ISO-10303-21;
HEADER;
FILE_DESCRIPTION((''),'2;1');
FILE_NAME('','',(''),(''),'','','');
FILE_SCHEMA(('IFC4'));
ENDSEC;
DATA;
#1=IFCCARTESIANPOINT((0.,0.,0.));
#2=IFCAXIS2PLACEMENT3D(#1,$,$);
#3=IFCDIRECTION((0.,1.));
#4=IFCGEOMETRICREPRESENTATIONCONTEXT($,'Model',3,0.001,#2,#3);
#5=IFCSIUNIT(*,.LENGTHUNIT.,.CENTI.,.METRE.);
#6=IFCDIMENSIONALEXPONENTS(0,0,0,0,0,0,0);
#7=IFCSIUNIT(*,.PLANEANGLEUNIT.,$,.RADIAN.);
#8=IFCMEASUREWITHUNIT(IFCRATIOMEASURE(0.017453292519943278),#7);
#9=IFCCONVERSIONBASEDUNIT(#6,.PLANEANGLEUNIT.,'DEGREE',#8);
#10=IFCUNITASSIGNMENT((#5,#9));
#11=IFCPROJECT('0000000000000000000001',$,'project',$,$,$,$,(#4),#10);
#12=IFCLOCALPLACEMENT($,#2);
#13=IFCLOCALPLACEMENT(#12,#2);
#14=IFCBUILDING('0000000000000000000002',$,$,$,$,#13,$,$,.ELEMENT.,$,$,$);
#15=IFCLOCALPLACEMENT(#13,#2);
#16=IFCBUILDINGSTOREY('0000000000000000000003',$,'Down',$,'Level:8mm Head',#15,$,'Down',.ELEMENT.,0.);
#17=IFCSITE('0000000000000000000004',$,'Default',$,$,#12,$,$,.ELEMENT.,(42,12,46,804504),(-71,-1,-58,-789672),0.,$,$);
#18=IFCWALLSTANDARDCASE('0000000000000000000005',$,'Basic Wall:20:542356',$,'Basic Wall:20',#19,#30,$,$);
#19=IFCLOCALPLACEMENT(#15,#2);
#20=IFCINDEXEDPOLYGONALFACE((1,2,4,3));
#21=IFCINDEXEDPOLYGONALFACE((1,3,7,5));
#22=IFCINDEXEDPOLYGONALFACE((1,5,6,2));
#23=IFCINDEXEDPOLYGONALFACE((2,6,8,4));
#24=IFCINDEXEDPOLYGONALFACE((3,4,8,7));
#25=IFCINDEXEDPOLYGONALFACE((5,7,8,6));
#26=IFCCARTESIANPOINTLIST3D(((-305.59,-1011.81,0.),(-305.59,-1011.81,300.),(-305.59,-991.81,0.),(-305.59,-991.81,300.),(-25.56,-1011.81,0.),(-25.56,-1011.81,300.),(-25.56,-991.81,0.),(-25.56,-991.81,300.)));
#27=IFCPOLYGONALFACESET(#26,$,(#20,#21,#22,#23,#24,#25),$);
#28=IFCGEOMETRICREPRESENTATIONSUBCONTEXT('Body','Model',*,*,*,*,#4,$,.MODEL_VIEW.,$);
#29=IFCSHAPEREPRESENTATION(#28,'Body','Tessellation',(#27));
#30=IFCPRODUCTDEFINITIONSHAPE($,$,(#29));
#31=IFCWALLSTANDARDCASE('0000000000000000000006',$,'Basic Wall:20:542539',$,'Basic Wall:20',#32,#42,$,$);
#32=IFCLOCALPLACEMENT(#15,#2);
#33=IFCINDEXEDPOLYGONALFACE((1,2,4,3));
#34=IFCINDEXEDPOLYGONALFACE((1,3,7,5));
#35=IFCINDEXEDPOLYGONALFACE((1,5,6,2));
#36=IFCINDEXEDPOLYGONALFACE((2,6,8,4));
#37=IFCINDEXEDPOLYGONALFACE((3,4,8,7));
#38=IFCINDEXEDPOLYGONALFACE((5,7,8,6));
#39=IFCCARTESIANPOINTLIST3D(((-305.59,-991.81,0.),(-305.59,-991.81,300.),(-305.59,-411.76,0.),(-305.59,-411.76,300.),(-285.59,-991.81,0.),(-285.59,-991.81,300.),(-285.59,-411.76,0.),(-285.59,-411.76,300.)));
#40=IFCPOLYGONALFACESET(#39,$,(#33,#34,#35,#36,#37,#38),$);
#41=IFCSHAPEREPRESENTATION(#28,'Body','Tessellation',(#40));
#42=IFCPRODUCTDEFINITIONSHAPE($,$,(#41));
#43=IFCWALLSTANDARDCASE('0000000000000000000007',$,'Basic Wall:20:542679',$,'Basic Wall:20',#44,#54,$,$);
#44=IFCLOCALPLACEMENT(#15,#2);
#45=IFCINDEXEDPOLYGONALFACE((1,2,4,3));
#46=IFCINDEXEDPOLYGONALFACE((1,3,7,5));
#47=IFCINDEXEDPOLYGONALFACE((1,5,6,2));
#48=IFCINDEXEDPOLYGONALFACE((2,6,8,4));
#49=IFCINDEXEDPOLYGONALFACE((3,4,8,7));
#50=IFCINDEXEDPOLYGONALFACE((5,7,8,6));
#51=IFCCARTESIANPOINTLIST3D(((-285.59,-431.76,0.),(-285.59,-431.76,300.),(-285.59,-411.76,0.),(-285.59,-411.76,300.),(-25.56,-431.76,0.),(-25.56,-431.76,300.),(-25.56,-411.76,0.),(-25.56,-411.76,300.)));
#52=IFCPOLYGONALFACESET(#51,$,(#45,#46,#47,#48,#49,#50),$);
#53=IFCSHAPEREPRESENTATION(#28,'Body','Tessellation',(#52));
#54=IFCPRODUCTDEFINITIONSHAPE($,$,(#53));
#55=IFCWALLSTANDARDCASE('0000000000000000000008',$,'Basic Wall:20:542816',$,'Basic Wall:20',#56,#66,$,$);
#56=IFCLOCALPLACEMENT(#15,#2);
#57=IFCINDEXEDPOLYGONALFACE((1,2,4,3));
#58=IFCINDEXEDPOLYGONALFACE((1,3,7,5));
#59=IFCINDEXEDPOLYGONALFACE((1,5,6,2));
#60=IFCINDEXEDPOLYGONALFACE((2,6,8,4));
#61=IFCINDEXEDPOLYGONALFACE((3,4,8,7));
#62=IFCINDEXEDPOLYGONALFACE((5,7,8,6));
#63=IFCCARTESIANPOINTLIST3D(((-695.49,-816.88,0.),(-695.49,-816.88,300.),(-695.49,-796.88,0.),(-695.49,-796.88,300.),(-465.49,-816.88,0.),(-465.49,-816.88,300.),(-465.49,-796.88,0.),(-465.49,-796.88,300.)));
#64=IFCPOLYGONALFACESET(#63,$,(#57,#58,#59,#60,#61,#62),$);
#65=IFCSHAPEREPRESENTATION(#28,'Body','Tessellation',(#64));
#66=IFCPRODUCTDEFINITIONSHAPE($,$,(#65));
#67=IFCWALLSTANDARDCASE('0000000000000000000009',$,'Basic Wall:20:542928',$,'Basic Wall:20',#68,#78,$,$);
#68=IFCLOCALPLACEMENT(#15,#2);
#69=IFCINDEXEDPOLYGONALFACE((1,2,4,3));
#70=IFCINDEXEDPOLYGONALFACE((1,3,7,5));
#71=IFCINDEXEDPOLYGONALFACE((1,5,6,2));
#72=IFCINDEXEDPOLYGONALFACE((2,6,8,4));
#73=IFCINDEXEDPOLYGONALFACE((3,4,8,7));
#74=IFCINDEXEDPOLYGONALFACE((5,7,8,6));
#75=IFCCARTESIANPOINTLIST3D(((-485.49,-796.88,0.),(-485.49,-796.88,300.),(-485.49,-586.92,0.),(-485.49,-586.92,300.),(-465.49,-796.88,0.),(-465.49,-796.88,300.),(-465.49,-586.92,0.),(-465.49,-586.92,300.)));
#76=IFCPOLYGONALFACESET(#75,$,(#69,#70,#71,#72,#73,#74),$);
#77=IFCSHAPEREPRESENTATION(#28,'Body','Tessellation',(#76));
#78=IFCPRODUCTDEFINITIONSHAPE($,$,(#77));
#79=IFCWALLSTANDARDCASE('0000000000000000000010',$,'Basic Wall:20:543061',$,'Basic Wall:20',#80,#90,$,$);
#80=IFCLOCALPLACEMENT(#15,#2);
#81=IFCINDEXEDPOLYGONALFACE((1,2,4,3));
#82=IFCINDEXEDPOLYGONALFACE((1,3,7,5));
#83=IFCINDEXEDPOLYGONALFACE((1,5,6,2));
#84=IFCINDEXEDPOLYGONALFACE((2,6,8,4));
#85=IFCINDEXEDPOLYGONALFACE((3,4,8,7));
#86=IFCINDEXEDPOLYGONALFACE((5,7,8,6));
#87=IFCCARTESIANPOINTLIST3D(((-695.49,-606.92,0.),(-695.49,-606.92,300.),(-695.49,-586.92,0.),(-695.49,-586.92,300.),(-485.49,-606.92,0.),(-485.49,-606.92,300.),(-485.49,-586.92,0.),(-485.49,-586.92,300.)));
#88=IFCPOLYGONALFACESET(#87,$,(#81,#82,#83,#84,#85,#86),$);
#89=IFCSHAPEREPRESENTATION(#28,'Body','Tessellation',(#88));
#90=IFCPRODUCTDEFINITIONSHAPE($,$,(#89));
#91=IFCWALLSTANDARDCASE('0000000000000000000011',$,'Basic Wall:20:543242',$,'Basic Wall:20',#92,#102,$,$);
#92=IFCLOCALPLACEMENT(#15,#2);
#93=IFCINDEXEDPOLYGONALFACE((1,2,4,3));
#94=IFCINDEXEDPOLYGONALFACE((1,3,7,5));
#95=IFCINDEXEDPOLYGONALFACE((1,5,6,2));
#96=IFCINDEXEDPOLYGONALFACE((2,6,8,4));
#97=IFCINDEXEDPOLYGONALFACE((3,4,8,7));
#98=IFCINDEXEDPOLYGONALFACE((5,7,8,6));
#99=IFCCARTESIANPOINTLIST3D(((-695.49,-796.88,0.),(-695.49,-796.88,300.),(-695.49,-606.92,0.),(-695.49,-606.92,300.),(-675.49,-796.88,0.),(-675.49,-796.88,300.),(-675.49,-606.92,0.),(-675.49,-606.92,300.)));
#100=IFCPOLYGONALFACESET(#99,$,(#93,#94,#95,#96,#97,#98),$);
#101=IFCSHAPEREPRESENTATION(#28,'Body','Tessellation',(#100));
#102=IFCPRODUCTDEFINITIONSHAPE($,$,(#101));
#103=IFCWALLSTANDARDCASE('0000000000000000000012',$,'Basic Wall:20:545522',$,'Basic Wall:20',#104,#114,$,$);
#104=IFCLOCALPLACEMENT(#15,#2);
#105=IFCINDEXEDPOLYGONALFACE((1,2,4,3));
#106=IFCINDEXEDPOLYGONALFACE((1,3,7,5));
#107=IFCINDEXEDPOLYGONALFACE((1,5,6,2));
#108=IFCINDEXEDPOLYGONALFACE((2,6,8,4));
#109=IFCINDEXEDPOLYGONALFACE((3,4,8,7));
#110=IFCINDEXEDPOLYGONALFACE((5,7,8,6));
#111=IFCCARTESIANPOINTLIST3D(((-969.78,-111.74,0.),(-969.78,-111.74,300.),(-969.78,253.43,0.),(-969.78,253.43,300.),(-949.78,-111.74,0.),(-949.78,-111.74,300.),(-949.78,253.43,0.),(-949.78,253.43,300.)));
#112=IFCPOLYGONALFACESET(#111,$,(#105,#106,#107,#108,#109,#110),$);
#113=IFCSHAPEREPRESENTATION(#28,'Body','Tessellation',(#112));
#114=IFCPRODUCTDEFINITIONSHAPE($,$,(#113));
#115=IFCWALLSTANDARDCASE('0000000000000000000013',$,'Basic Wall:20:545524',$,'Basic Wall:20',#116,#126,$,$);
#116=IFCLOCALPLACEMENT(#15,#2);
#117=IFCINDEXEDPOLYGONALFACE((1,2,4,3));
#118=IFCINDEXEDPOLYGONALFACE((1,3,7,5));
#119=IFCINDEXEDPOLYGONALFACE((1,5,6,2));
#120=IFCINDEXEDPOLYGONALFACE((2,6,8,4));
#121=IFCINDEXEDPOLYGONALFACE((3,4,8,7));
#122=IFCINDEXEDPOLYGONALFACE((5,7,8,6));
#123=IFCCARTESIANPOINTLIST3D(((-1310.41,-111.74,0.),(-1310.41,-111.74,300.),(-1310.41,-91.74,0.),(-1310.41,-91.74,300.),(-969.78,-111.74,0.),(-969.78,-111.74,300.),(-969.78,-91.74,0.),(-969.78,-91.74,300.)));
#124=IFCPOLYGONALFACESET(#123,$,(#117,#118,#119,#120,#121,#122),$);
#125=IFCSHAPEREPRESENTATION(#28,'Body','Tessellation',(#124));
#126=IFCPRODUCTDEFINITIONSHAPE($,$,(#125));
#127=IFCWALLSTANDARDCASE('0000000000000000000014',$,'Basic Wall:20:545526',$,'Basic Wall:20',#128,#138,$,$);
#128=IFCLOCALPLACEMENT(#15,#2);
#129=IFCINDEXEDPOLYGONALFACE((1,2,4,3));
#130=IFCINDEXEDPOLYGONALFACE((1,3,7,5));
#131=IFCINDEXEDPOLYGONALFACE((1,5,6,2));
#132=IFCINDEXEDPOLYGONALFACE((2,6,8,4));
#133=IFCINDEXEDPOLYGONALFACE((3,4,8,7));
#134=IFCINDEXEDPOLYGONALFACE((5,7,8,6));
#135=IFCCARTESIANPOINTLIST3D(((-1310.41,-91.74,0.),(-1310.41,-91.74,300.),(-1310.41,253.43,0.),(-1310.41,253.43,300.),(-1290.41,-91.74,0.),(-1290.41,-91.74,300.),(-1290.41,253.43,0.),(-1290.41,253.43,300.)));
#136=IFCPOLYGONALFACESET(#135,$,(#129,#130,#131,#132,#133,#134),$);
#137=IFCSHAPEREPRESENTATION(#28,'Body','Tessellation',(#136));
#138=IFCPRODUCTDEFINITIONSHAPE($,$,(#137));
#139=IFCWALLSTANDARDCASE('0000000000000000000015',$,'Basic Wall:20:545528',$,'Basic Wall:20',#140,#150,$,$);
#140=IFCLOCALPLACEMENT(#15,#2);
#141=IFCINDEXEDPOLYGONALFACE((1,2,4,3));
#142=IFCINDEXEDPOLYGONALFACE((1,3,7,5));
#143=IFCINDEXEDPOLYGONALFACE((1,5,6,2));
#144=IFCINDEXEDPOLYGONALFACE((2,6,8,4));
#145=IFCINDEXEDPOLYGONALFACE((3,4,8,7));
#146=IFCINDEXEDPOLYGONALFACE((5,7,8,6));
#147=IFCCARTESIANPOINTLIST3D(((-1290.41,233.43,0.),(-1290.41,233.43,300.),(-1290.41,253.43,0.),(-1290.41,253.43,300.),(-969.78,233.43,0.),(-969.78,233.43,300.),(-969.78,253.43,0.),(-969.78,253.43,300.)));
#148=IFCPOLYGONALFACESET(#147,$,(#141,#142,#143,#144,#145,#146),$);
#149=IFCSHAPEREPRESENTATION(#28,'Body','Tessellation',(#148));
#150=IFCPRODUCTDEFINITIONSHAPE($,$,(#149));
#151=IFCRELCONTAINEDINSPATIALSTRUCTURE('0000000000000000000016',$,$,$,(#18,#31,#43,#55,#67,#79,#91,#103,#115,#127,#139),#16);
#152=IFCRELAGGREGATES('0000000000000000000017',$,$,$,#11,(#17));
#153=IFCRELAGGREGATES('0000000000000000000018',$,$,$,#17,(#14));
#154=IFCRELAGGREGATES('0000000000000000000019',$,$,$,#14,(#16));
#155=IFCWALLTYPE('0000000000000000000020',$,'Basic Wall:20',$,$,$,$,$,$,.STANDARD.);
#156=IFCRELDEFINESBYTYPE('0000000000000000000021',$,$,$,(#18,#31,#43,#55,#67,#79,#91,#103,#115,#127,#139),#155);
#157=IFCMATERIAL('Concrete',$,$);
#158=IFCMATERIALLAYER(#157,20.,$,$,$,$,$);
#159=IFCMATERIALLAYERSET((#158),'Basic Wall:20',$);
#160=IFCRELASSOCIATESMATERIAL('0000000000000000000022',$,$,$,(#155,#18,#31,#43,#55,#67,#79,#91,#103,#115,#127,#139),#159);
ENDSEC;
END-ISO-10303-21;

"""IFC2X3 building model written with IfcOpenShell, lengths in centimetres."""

from ifc_helpers import new_model, entity, si_unit, converted_unit, direction, frame, frame_2d, origin, place, context, subcontext, project, spatial, rectangle, extrude, material, layer, layer_set, layer_usage, type_object, element, save


model = new_model("IFC2X3")

# Units and contexts
model_context = context("Model", 3, precision=0.001, world=origin(), true_north=direction((0.0, 1.0)))
body_context = subcontext(model_context, "Body", "Model", "MODEL_VIEW")
ifc_project = project(units=[si_unit("LENGTHUNIT", "METRE", prefix="CENTI"), converted_unit("PLANEANGLEUNIT", "DEGREE", entity("IfcRatioMeasure", 0.017453292519943278), si_unit("PLANEANGLEUNIT", "RADIAN"), dimensions=[0, 0, 0, 0, 0, 0, 0])], contexts=[model_context])

# Site, building, storey
site_placement = place(None, origin())
site = spatial("IfcSite", under=ifc_project, at=site_placement, Name="Default", CompositionType="ELEMENT", RefLatitude=(42, 12, 46, 804504), RefLongitude=(-71, -1, -58, -789672), RefElevation=0.0)
building_placement = place(site_placement, origin())
building = spatial("IfcBuilding", under=site, at=building_placement, CompositionType="ELEMENT")
storey_placement = place(building_placement, origin())
storey = spatial("IfcBuildingStorey", under=building, at=storey_placement, Name="Down", ObjectType="Level:8mm Head", LongName="Down", CompositionType="ELEMENT", Elevation=0.0)

# Shared definitions
ifc_material = material(Name="Concrete")

# Walls
ifc_layer = layer(ifc_material, 20.0)
ifc_layer_set = layer_set([ifc_layer], Name="Basic Wall:20")
wall_type = type_object("IfcWallType", Name="Basic Wall:20", PredefinedType="STANDARD", material=ifc_layer_set)
ifc_layer_usage_1 = layer_usage(ifc_layer_set, "AXIS2", "NEGATIVE", 10.0)
wall_1_placement = place(storey_placement, frame((-25.56, -1001.81, 0.0), z_axis=(0.0, 0.0, 1.0), x_axis=(-1.0, 0.0, 0.0)))
element("IfcWallStandardCase", 1, at=wall_1_placement, inside=storey, type_object=wall_type, material=ifc_layer_usage_1, Name="Basic Wall:20:542356", ObjectType="Basic Wall:20", context=body_context, shape_type="SweptSolid", body=[
    extrude(rectangle(XDim=280.02, YDim=20.0, at=frame_2d((140.01, 0.0), x_axis=(-1.0, 0.0))), origin(), (0.0, 0.0, 1.0), 300.0),
])
ifc_layer_usage_2 = layer_usage(ifc_layer_set, "AXIS2", "NEGATIVE", 10.0)
wall_2_placement = place(storey_placement, frame((-295.59, -991.81, 0.0), z_axis=(0.0, 0.0, 1.0), x_axis=(0.0, 1.0, 0.0)))
element("IfcWallStandardCase", 2, at=wall_2_placement, inside=storey, type_object=wall_type, material=ifc_layer_usage_2, Name="Basic Wall:20:542539", ObjectType="Basic Wall:20", context=body_context, shape_type="SweptSolid", body=[
    extrude(rectangle(XDim=580.05, YDim=20.0, at=frame_2d((290.02, 0.0), x_axis=(-1.0, 0.0))), origin(), (0.0, 0.0, 1.0), 300.0),
])
ifc_layer_usage_3 = layer_usage(ifc_layer_set, "AXIS2", "NEGATIVE", 10.0)
wall_3_placement = place(storey_placement, frame((-285.59, -421.76, 0.0)))
element("IfcWallStandardCase", 3, at=wall_3_placement, inside=storey, type_object=wall_type, material=ifc_layer_usage_3, Name="Basic Wall:20:542679", ObjectType="Basic Wall:20", context=body_context, shape_type="SweptSolid", body=[
    extrude(rectangle(XDim=260.02, YDim=20.0, at=frame_2d((130.01, 0.0), x_axis=(-1.0, 0.0))), origin(), (0.0, 0.0, 1.0), 300.0),
])
ifc_layer_usage_4 = layer_usage(ifc_layer_set, "AXIS2", "POSITIVE", -10.0)
wall_4_placement = place(storey_placement, frame((-695.49, -806.88, 0.0)))
element("IfcWallStandardCase", 4, at=wall_4_placement, inside=storey, type_object=wall_type, material=ifc_layer_usage_4, Name="Basic Wall:20:542816", ObjectType="Basic Wall:20", context=body_context, shape_type="SweptSolid", body=[
    extrude(rectangle(XDim=230.0, YDim=20.0, at=frame_2d((115.0, 0.0), x_axis=(-1.0, 0.0))), origin(), (0.0, 0.0, 1.0), 300.0),
])
ifc_layer_usage_5 = layer_usage(ifc_layer_set, "AXIS2", "POSITIVE", -10.0)
wall_5_placement = place(storey_placement, frame((-475.49, -796.88, 0.0), z_axis=(0.0, 0.0, 1.0), x_axis=(0.0, 1.0, 0.0)))
element("IfcWallStandardCase", 5, at=wall_5_placement, inside=storey, type_object=wall_type, material=ifc_layer_usage_5, Name="Basic Wall:20:542928", ObjectType="Basic Wall:20", context=body_context, shape_type="SweptSolid", body=[
    extrude(rectangle(XDim=209.96, YDim=20.0, at=frame_2d((104.98, 0.0), x_axis=(-1.0, 0.0))), origin(), (0.0, 0.0, 1.0), 300.0),
])
ifc_layer_usage_6 = layer_usage(ifc_layer_set, "AXIS2", "POSITIVE", -10.0)
wall_6_placement = place(storey_placement, frame((-485.49, -596.92, 0.0), z_axis=(0.0, 0.0, 1.0), x_axis=(-1.0, 0.0, 0.0)))
element("IfcWallStandardCase", 6, at=wall_6_placement, inside=storey, type_object=wall_type, material=ifc_layer_usage_6, Name="Basic Wall:20:543061", ObjectType="Basic Wall:20", context=body_context, shape_type="SweptSolid", body=[
    extrude(rectangle(XDim=210.0, YDim=20.0, at=frame_2d((105.0, 0.0), x_axis=(-1.0, 0.0))), origin(), (0.0, 0.0, 1.0), 300.0),
])
ifc_layer_usage_7 = layer_usage(ifc_layer_set, "AXIS2", "POSITIVE", -10.0)
wall_7_placement = place(storey_placement, frame((-685.49, -606.92, 0.0), z_axis=(0.0, 0.0, 1.0), x_axis=(0.0, -1.0, 0.0)))
element("IfcWallStandardCase", 7, at=wall_7_placement, inside=storey, type_object=wall_type, material=ifc_layer_usage_7, Name="Basic Wall:20:543242", ObjectType="Basic Wall:20", context=body_context, shape_type="SweptSolid", body=[
    extrude(rectangle(XDim=189.96, YDim=20.0, at=frame_2d((94.98, 0.0), x_axis=(-1.0, 0.0))), origin(), (0.0, 0.0, 1.0), 300.0),
])
ifc_layer_usage_8 = layer_usage(ifc_layer_set, "AXIS2", "NEGATIVE", 10.0)
wall_8_placement = place(storey_placement, frame((-959.78, 253.43, 0.0), z_axis=(0.0, 0.0, 1.0), x_axis=(0.0, -1.0, 0.0)))
element("IfcWallStandardCase", 8, at=wall_8_placement, inside=storey, type_object=wall_type, material=ifc_layer_usage_8, Name="Basic Wall:20:545522", ObjectType="Basic Wall:20", context=body_context, shape_type="SweptSolid", body=[
    extrude(rectangle(XDim=365.17, YDim=20.0, at=frame_2d((182.58, 0.0), x_axis=(-1.0, 0.0))), origin(), (0.0, 0.0, 1.0), 300.0),
])
ifc_layer_usage_9 = layer_usage(ifc_layer_set, "AXIS2", "NEGATIVE", 10.0)
wall_9_placement = place(storey_placement, frame((-969.78, -101.74, 0.0), z_axis=(0.0, 0.0, 1.0), x_axis=(-1.0, 0.0, 0.0)))
element("IfcWallStandardCase", 9, at=wall_9_placement, inside=storey, type_object=wall_type, material=ifc_layer_usage_9, Name="Basic Wall:20:545524", ObjectType="Basic Wall:20", context=body_context, shape_type="SweptSolid", body=[
    extrude(rectangle(XDim=340.63, YDim=20.0, at=frame_2d((170.31, 0.0), x_axis=(-1.0, 0.0))), origin(), (0.0, 0.0, 1.0), 300.0),
])
ifc_layer_usage_10 = layer_usage(ifc_layer_set, "AXIS2", "NEGATIVE", 10.0)
wall_10_placement = place(storey_placement, frame((-1300.41, -91.74, 0.0), z_axis=(0.0, 0.0, 1.0), x_axis=(0.0, 1.0, 0.0)))
element("IfcWallStandardCase", 10, at=wall_10_placement, inside=storey, type_object=wall_type, material=ifc_layer_usage_10, Name="Basic Wall:20:545526", ObjectType="Basic Wall:20", context=body_context, shape_type="SweptSolid", body=[
    extrude(rectangle(XDim=345.17, YDim=20.0, at=frame_2d((172.58, 0.0), x_axis=(-1.0, 0.0))), origin(), (0.0, 0.0, 1.0), 300.0),
])
ifc_layer_usage_11 = layer_usage(ifc_layer_set, "AXIS2", "NEGATIVE", 10.0)
wall_11_placement = place(storey_placement, frame((-1290.41, 243.43, 0.0)))
element("IfcWallStandardCase", 11, at=wall_11_placement, inside=storey, type_object=wall_type, material=ifc_layer_usage_11, Name="Basic Wall:20:545528", ObjectType="Basic Wall:20", context=body_context, shape_type="SweptSolid", body=[
    extrude(rectangle(XDim=320.63, YDim=20.0, at=frame_2d((160.31, 0.0), x_axis=(-1.0, 0.0))), origin(), (0.0, 0.0, 1.0), 300.0),
])

save(model, "model.ifc")
